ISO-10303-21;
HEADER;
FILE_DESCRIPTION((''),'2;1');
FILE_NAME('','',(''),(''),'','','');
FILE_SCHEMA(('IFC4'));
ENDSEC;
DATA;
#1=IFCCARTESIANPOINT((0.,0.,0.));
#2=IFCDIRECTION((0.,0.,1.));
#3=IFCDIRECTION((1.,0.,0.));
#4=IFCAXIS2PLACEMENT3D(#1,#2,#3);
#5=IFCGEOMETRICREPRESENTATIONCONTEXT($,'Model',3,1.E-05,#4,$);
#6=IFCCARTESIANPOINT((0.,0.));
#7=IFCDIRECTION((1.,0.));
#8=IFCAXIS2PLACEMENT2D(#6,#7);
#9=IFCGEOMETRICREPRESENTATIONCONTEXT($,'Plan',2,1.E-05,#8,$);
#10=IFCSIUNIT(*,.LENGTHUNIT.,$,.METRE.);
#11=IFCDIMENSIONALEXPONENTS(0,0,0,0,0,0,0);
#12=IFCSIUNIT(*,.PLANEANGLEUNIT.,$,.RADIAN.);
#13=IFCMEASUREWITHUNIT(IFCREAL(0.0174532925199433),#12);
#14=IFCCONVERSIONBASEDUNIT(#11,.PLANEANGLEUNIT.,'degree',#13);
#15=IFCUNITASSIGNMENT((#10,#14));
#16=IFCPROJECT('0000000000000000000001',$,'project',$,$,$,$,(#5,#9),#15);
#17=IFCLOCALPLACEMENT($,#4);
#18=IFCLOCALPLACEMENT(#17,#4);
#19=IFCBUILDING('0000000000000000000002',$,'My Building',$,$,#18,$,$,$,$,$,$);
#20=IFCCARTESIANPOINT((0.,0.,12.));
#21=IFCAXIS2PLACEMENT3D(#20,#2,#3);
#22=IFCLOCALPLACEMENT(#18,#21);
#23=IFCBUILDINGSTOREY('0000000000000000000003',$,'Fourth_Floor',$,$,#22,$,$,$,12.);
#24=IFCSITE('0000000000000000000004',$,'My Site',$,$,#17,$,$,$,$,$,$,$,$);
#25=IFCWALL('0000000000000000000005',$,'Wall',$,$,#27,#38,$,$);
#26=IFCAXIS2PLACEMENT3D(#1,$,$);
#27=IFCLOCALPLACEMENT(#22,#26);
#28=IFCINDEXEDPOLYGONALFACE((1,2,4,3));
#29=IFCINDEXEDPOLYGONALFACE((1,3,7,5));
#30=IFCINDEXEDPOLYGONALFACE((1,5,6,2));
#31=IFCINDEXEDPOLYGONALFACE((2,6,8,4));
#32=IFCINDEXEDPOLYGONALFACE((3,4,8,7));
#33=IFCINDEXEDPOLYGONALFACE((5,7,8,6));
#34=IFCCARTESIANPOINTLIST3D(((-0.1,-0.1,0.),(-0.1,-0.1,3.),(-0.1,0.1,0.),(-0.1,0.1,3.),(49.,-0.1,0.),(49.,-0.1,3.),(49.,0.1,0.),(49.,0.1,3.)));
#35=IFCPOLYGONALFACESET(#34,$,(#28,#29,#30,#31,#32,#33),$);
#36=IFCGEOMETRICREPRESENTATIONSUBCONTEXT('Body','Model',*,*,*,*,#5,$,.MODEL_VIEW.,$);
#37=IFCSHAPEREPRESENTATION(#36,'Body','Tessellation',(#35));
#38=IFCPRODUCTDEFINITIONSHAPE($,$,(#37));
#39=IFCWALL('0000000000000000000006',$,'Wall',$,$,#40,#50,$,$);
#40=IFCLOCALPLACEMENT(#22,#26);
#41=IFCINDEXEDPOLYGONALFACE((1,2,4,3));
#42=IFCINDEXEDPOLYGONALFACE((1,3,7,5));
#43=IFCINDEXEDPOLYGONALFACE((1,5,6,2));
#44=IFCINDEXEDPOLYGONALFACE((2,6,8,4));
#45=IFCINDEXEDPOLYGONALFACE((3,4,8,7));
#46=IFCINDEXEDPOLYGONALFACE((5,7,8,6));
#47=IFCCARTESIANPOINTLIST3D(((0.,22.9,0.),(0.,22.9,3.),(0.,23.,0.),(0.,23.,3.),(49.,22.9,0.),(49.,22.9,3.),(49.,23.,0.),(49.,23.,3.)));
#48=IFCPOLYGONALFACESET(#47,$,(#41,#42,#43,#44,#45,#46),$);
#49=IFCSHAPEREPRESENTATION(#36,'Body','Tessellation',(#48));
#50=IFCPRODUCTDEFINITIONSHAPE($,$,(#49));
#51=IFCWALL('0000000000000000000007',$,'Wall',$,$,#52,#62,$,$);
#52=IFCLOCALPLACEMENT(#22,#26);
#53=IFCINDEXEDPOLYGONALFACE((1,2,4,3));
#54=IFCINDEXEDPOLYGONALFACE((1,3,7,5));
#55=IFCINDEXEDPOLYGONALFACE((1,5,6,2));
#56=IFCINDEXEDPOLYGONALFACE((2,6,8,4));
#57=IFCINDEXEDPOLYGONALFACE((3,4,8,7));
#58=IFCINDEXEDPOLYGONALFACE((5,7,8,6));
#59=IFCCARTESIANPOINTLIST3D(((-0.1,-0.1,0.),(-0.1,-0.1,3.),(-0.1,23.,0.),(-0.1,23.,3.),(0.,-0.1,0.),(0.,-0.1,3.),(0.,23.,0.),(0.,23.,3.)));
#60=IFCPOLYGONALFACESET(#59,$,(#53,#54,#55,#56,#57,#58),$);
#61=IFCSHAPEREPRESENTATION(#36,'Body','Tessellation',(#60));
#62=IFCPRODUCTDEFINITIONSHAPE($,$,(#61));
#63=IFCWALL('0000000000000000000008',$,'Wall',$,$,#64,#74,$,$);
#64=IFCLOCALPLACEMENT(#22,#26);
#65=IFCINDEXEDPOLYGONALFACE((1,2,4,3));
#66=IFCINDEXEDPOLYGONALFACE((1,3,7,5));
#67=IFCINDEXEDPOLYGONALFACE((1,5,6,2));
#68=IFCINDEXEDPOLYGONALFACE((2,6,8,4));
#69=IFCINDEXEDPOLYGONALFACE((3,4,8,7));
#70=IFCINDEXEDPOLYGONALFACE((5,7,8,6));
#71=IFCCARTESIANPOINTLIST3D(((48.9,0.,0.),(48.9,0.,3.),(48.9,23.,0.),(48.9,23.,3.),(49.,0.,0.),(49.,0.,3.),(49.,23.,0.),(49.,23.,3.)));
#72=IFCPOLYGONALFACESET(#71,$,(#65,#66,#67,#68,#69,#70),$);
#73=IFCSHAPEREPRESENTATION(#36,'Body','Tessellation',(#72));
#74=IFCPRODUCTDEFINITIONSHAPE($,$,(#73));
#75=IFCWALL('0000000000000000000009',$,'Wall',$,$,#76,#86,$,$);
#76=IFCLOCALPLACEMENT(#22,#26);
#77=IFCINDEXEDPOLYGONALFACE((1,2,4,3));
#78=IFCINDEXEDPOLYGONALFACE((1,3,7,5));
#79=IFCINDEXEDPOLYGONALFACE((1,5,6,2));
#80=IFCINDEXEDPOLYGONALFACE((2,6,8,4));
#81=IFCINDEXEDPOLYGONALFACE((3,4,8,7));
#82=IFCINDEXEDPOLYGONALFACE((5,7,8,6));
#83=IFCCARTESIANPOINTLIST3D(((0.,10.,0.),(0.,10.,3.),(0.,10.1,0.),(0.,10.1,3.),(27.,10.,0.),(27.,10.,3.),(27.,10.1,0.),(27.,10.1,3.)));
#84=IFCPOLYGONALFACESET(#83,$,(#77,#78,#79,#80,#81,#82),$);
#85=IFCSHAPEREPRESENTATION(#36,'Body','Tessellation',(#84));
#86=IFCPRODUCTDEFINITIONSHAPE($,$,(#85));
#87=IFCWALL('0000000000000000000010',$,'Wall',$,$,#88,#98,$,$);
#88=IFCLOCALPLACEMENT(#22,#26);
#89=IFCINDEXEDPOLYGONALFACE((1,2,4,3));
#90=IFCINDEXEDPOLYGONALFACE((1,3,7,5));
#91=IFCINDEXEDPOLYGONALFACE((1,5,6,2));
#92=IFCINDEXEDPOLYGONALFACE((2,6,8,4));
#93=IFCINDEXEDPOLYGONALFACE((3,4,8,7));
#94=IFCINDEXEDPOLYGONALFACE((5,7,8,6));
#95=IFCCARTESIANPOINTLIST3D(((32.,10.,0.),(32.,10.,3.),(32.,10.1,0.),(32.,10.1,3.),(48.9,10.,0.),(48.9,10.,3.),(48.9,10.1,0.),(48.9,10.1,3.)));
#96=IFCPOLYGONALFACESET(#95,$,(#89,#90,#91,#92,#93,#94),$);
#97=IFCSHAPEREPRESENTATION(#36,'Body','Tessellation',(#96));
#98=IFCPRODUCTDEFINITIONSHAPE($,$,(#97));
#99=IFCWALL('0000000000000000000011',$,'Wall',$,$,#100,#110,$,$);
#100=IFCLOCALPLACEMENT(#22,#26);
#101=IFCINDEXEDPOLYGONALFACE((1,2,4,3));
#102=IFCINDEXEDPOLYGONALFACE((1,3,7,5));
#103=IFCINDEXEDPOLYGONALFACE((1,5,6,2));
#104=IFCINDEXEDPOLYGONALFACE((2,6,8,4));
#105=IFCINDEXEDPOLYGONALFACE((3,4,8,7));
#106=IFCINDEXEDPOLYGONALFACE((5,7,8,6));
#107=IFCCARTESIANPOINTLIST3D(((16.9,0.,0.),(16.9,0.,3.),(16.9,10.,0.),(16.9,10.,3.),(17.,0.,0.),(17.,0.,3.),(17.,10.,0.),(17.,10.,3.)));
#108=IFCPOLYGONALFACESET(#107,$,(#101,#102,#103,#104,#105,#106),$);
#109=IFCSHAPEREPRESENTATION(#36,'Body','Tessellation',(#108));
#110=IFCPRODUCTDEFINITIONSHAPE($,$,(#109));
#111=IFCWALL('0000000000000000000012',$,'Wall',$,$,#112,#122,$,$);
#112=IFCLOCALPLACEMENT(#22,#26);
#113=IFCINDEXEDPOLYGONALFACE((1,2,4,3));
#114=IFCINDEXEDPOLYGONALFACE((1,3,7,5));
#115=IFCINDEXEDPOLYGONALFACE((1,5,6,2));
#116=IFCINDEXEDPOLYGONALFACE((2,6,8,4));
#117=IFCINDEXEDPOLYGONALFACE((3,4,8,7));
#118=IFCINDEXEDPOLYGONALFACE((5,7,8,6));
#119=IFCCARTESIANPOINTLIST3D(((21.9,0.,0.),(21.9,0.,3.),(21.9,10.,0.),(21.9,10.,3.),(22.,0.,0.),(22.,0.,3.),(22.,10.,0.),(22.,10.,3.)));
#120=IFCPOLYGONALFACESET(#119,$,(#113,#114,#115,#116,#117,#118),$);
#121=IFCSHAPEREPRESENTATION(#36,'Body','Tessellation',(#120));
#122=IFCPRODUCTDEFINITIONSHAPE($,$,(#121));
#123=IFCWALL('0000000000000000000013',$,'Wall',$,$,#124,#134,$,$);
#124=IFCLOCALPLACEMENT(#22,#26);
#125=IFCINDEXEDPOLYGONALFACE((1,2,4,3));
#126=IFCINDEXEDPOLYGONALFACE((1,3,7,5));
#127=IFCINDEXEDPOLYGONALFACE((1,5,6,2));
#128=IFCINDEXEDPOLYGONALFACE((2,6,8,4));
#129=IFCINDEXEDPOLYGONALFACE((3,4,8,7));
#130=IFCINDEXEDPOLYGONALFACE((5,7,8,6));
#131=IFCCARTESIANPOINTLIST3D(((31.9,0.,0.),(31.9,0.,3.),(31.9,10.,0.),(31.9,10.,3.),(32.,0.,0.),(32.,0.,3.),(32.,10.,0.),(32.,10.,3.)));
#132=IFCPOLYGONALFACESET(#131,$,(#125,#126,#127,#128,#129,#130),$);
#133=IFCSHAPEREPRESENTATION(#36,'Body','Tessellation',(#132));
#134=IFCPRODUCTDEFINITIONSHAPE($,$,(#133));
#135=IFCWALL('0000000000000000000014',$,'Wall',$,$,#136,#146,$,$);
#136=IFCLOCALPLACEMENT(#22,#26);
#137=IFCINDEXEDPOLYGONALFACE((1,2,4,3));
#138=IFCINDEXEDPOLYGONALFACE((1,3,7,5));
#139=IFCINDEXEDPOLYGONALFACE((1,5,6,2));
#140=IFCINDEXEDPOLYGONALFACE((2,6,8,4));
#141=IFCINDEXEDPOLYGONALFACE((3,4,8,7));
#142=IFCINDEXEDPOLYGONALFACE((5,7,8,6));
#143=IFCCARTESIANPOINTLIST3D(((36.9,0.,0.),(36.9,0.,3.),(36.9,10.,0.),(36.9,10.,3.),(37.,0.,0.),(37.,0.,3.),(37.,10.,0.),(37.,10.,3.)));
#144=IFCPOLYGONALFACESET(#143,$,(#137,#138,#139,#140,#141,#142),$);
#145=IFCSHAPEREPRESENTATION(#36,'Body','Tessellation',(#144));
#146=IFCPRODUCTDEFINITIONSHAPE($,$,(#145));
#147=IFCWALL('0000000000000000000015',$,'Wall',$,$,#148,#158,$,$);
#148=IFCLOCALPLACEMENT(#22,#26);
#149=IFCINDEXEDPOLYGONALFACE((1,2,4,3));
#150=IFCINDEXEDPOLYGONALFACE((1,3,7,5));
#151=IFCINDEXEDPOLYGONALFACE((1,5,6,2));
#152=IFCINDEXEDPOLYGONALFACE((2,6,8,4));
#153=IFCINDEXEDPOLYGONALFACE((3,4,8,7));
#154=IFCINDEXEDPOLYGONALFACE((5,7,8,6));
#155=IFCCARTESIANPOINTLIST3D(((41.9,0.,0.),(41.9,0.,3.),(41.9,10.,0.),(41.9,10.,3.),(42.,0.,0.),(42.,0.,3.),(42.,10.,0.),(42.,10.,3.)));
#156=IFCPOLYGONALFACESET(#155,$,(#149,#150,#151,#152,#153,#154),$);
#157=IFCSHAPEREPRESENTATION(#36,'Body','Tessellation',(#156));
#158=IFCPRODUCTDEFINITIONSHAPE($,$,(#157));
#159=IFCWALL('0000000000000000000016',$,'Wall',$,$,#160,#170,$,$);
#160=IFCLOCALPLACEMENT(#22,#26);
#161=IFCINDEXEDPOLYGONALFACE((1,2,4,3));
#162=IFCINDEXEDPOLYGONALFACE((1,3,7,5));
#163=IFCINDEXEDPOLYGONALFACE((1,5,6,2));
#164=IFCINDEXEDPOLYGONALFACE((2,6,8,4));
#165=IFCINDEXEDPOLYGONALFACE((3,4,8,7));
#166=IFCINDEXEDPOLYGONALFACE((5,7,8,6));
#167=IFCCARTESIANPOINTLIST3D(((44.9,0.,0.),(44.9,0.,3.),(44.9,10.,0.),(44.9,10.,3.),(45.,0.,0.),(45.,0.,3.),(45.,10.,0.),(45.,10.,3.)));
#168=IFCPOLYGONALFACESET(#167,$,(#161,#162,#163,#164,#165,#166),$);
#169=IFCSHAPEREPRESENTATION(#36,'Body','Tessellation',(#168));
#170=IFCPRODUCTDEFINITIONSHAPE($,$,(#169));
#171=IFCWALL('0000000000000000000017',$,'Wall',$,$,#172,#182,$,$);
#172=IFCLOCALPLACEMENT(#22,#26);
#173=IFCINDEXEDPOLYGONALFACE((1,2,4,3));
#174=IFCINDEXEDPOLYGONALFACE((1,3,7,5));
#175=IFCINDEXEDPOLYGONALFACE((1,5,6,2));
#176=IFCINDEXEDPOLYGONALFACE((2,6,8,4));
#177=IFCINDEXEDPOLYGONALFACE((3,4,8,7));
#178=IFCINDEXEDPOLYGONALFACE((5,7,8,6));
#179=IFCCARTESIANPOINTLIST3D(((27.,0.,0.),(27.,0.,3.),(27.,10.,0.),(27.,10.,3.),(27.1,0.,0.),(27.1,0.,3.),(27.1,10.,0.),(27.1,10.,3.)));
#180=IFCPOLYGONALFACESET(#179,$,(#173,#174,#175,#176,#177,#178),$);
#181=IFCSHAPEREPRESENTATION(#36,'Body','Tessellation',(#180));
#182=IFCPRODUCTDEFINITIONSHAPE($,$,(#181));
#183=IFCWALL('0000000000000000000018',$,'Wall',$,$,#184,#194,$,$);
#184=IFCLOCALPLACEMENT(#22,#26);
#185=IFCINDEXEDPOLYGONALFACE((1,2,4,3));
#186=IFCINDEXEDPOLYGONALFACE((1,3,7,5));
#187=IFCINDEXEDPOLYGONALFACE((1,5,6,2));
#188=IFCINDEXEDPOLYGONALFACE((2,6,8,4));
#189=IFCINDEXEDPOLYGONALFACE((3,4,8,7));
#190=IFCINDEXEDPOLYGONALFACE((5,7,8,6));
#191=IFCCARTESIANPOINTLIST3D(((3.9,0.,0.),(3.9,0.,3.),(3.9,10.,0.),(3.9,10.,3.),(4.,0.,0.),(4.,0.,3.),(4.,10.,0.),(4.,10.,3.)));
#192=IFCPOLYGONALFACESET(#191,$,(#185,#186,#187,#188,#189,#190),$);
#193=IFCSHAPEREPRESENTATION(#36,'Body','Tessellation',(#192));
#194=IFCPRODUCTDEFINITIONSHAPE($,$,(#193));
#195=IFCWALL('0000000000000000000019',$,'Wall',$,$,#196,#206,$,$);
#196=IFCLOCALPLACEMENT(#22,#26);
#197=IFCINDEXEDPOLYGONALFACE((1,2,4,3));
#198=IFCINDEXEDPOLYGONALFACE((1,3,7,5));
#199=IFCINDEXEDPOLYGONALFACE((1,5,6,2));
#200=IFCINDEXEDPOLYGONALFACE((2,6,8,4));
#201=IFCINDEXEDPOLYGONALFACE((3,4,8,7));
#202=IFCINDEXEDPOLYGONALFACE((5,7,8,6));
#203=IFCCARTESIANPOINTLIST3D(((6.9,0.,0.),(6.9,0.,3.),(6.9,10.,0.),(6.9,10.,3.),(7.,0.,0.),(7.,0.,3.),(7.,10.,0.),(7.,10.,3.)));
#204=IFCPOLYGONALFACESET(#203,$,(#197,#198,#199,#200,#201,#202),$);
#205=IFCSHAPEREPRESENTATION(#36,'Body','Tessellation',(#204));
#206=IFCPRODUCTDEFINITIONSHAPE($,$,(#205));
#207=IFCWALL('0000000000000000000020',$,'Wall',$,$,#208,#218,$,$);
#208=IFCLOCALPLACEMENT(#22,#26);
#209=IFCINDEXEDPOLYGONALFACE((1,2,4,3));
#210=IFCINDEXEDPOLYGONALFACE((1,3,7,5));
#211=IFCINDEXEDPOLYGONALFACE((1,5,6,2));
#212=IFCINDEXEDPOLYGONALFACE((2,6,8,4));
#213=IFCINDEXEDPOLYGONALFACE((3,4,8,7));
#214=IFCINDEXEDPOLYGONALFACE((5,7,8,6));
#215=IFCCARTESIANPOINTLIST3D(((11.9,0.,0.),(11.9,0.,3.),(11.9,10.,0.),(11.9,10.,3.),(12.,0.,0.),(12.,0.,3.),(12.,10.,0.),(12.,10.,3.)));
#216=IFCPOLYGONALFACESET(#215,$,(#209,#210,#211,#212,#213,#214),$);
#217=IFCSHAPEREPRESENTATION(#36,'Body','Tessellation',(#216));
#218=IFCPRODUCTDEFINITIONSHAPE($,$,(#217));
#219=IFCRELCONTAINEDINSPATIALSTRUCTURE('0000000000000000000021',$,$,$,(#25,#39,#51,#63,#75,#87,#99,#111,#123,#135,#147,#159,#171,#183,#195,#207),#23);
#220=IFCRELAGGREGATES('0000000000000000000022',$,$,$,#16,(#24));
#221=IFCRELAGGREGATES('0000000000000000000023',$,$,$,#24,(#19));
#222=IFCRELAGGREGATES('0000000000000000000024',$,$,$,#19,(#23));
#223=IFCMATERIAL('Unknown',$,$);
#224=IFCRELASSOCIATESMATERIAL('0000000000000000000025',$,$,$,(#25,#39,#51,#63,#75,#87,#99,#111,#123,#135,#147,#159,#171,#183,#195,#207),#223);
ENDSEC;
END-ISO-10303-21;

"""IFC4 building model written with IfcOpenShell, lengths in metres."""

from ifc_helpers import new_model, entity, si_unit, converted_unit, frame, frame_2d, origin, origin_with_axes, origin_2d_with_axis, place, context, subcontext, project, spatial, rectangle, extrude, material, element, save


model = new_model("IFC4")

# Units and contexts
model_context = context("Model", 3, precision=1e-05, world=origin_with_axes())
plan_context = context("Plan", 2, precision=1e-05, world=origin_2d_with_axis())
body_context = subcontext(model_context, "Body", "Model", "MODEL_VIEW")
ifc_project = project(units=[si_unit("LENGTHUNIT", "METRE"), converted_unit("PLANEANGLEUNIT", "degree", entity("IfcReal", 0.0174532925199433), si_unit("PLANEANGLEUNIT", "RADIAN"), dimensions=[0, 0, 0, 0, 0, 0, 0])], contexts=[model_context, plan_context])

# Site, building, storey
site_placement = place(None, origin_with_axes())
site = spatial("IfcSite", under=ifc_project, at=site_placement, Name="My Site")
building_placement = place(site_placement, origin_with_axes())
building = spatial("IfcBuilding", under=site, at=building_placement, Name="My Building")
storey_placement = place(building_placement, frame((0.0, 0.0, 12.0), z_axis=(0.0, 0.0, 1.0), x_axis=(1.0, 0.0, 0.0)))
storey = spatial("IfcBuildingStorey", under=building, at=storey_placement, Name="Fourth_Floor", Elevation=12.0)

# Walls
ifc_material = material(Name="Unknown")
wall_1_placement = place(storey_placement, origin_with_axes())
element("IfcWall", 1, at=wall_1_placement, inside=storey, material=ifc_material, Name="Wall", context=body_context, shape_type="SweptSolid", body=[
    extrude(rectangle(XDim=49.1, YDim=0.2, at=frame_2d((24.45, 0.0))), origin(), (0.0, 0.0, 1.0), 3.0),
])
wall_2_placement = place(storey_placement, origin_with_axes())
element("IfcWall", 2, at=wall_2_placement, inside=storey, material=ifc_material, Name="Wall", context=body_context, shape_type="SweptSolid", body=[
    extrude(rectangle(XDim=49.0, YDim=0.1, at=frame_2d((24.5, 22.95))), origin(), (0.0, 0.0, 1.0), 3.0),
])
wall_3_placement = place(storey_placement, origin_with_axes())
element("IfcWall", 3, at=wall_3_placement, inside=storey, material=ifc_material, Name="Wall", context=body_context, shape_type="SweptSolid", body=[
    extrude(rectangle(XDim=0.1, YDim=23.1, at=frame_2d((-0.05, 11.45))), origin(), (0.0, 0.0, 1.0), 3.0),
])
wall_4_placement = place(storey_placement, origin_with_axes())
element("IfcWall", 4, at=wall_4_placement, inside=storey, material=ifc_material, Name="Wall", context=body_context, shape_type="SweptSolid", body=[
    extrude(rectangle(XDim=0.1, YDim=23.0, at=frame_2d((48.95, 11.5))), origin(), (0.0, 0.0, 1.0), 3.0),
])
wall_5_placement = place(storey_placement, origin_with_axes())
element("IfcWall", 5, at=wall_5_placement, inside=storey, material=ifc_material, Name="Wall", context=body_context, shape_type="SweptSolid", body=[
    extrude(rectangle(XDim=27.0, YDim=0.1, at=frame_2d((13.5, 10.05))), origin(), (0.0, 0.0, 1.0), 3.0),
])
wall_6_placement = place(storey_placement, origin_with_axes())
element("IfcWall", 6, at=wall_6_placement, inside=storey, material=ifc_material, Name="Wall", context=body_context, shape_type="SweptSolid", body=[
    extrude(rectangle(XDim=16.9, YDim=0.1, at=frame_2d((40.45, 10.05))), origin(), (0.0, 0.0, 1.0), 3.0),
])
wall_7_placement = place(storey_placement, origin_with_axes())
element("IfcWall", 7, at=wall_7_placement, inside=storey, material=ifc_material, Name="Wall", context=body_context, shape_type="SweptSolid", body=[
    extrude(rectangle(XDim=0.1, YDim=10.0, at=frame_2d((16.95, 5.0))), origin(), (0.0, 0.0, 1.0), 3.0),
])
wall_8_placement = place(storey_placement, origin_with_axes())
element("IfcWall", 8, at=wall_8_placement, inside=storey, material=ifc_material, Name="Wall", context=body_context, shape_type="SweptSolid", body=[
    extrude(rectangle(XDim=0.1, YDim=10.0, at=frame_2d((21.95, 5.0))), origin(), (0.0, 0.0, 1.0), 3.0),
])
wall_9_placement = place(storey_placement, origin_with_axes())
element("IfcWall", 9, at=wall_9_placement, inside=storey, material=ifc_material, Name="Wall", context=body_context, shape_type="SweptSolid", body=[
    extrude(rectangle(XDim=0.1, YDim=10.0, at=frame_2d((31.95, 5.0))), origin(), (0.0, 0.0, 1.0), 3.0),
])
wall_10_placement = place(storey_placement, origin_with_axes())
element("IfcWall", 10, at=wall_10_placement, inside=storey, material=ifc_material, Name="Wall", context=body_context, shape_type="SweptSolid", body=[
    extrude(rectangle(XDim=0.1, YDim=10.0, at=frame_2d((36.95, 5.0))), origin(), (0.0, 0.0, 1.0), 3.0),
])
wall_11_placement = place(storey_placement, origin_with_axes())
element("IfcWall", 11, at=wall_11_placement, inside=storey, material=ifc_material, Name="Wall", context=body_context, shape_type="SweptSolid", body=[
    extrude(rectangle(XDim=0.1, YDim=10.0, at=frame_2d((41.95, 5.0))), origin(), (0.0, 0.0, 1.0), 3.0),
])
wall_12_placement = place(storey_placement, origin_with_axes())
element("IfcWall", 12, at=wall_12_placement, inside=storey, material=ifc_material, Name="Wall", context=body_context, shape_type="SweptSolid", body=[
    extrude(rectangle(XDim=0.1, YDim=10.0, at=frame_2d((44.95, 5.0))), origin(), (0.0, 0.0, 1.0), 3.0),
])
wall_13_placement = place(storey_placement, origin_with_axes())
element("IfcWall", 13, at=wall_13_placement, inside=storey, material=ifc_material, Name="Wall", context=body_context, shape_type="SweptSolid", body=[
    extrude(rectangle(XDim=0.1, YDim=10.0, at=frame_2d((27.05, 5.0))), origin(), (0.0, 0.0, 1.0), 3.0),
])
wall_14_placement = place(storey_placement, origin_with_axes())
element("IfcWall", 14, at=wall_14_placement, inside=storey, material=ifc_material, Name="Wall", context=body_context, shape_type="SweptSolid", body=[
    extrude(rectangle(XDim=0.1, YDim=10.0, at=frame_2d((3.95, 5.0))), origin(), (0.0, 0.0, 1.0), 3.0),
])
wall_15_placement = place(storey_placement, origin_with_axes())
element("IfcWall", 15, at=wall_15_placement, inside=storey, material=ifc_material, Name="Wall", context=body_context, shape_type="SweptSolid", body=[
    extrude(rectangle(XDim=0.1, YDim=10.0, at=frame_2d((6.95, 5.0))), origin(), (0.0, 0.0, 1.0), 3.0),
])
wall_16_placement = place(storey_placement, origin_with_axes())
element("IfcWall", 16, at=wall_16_placement, inside=storey, material=ifc_material, Name="Wall", context=body_context, shape_type="SweptSolid", body=[
    extrude(rectangle(XDim=0.1, YDim=10.0, at=frame_2d((11.95, 5.0))), origin(), (0.0, 0.0, 1.0), 3.0),
])

save(model, "model.ifc")
